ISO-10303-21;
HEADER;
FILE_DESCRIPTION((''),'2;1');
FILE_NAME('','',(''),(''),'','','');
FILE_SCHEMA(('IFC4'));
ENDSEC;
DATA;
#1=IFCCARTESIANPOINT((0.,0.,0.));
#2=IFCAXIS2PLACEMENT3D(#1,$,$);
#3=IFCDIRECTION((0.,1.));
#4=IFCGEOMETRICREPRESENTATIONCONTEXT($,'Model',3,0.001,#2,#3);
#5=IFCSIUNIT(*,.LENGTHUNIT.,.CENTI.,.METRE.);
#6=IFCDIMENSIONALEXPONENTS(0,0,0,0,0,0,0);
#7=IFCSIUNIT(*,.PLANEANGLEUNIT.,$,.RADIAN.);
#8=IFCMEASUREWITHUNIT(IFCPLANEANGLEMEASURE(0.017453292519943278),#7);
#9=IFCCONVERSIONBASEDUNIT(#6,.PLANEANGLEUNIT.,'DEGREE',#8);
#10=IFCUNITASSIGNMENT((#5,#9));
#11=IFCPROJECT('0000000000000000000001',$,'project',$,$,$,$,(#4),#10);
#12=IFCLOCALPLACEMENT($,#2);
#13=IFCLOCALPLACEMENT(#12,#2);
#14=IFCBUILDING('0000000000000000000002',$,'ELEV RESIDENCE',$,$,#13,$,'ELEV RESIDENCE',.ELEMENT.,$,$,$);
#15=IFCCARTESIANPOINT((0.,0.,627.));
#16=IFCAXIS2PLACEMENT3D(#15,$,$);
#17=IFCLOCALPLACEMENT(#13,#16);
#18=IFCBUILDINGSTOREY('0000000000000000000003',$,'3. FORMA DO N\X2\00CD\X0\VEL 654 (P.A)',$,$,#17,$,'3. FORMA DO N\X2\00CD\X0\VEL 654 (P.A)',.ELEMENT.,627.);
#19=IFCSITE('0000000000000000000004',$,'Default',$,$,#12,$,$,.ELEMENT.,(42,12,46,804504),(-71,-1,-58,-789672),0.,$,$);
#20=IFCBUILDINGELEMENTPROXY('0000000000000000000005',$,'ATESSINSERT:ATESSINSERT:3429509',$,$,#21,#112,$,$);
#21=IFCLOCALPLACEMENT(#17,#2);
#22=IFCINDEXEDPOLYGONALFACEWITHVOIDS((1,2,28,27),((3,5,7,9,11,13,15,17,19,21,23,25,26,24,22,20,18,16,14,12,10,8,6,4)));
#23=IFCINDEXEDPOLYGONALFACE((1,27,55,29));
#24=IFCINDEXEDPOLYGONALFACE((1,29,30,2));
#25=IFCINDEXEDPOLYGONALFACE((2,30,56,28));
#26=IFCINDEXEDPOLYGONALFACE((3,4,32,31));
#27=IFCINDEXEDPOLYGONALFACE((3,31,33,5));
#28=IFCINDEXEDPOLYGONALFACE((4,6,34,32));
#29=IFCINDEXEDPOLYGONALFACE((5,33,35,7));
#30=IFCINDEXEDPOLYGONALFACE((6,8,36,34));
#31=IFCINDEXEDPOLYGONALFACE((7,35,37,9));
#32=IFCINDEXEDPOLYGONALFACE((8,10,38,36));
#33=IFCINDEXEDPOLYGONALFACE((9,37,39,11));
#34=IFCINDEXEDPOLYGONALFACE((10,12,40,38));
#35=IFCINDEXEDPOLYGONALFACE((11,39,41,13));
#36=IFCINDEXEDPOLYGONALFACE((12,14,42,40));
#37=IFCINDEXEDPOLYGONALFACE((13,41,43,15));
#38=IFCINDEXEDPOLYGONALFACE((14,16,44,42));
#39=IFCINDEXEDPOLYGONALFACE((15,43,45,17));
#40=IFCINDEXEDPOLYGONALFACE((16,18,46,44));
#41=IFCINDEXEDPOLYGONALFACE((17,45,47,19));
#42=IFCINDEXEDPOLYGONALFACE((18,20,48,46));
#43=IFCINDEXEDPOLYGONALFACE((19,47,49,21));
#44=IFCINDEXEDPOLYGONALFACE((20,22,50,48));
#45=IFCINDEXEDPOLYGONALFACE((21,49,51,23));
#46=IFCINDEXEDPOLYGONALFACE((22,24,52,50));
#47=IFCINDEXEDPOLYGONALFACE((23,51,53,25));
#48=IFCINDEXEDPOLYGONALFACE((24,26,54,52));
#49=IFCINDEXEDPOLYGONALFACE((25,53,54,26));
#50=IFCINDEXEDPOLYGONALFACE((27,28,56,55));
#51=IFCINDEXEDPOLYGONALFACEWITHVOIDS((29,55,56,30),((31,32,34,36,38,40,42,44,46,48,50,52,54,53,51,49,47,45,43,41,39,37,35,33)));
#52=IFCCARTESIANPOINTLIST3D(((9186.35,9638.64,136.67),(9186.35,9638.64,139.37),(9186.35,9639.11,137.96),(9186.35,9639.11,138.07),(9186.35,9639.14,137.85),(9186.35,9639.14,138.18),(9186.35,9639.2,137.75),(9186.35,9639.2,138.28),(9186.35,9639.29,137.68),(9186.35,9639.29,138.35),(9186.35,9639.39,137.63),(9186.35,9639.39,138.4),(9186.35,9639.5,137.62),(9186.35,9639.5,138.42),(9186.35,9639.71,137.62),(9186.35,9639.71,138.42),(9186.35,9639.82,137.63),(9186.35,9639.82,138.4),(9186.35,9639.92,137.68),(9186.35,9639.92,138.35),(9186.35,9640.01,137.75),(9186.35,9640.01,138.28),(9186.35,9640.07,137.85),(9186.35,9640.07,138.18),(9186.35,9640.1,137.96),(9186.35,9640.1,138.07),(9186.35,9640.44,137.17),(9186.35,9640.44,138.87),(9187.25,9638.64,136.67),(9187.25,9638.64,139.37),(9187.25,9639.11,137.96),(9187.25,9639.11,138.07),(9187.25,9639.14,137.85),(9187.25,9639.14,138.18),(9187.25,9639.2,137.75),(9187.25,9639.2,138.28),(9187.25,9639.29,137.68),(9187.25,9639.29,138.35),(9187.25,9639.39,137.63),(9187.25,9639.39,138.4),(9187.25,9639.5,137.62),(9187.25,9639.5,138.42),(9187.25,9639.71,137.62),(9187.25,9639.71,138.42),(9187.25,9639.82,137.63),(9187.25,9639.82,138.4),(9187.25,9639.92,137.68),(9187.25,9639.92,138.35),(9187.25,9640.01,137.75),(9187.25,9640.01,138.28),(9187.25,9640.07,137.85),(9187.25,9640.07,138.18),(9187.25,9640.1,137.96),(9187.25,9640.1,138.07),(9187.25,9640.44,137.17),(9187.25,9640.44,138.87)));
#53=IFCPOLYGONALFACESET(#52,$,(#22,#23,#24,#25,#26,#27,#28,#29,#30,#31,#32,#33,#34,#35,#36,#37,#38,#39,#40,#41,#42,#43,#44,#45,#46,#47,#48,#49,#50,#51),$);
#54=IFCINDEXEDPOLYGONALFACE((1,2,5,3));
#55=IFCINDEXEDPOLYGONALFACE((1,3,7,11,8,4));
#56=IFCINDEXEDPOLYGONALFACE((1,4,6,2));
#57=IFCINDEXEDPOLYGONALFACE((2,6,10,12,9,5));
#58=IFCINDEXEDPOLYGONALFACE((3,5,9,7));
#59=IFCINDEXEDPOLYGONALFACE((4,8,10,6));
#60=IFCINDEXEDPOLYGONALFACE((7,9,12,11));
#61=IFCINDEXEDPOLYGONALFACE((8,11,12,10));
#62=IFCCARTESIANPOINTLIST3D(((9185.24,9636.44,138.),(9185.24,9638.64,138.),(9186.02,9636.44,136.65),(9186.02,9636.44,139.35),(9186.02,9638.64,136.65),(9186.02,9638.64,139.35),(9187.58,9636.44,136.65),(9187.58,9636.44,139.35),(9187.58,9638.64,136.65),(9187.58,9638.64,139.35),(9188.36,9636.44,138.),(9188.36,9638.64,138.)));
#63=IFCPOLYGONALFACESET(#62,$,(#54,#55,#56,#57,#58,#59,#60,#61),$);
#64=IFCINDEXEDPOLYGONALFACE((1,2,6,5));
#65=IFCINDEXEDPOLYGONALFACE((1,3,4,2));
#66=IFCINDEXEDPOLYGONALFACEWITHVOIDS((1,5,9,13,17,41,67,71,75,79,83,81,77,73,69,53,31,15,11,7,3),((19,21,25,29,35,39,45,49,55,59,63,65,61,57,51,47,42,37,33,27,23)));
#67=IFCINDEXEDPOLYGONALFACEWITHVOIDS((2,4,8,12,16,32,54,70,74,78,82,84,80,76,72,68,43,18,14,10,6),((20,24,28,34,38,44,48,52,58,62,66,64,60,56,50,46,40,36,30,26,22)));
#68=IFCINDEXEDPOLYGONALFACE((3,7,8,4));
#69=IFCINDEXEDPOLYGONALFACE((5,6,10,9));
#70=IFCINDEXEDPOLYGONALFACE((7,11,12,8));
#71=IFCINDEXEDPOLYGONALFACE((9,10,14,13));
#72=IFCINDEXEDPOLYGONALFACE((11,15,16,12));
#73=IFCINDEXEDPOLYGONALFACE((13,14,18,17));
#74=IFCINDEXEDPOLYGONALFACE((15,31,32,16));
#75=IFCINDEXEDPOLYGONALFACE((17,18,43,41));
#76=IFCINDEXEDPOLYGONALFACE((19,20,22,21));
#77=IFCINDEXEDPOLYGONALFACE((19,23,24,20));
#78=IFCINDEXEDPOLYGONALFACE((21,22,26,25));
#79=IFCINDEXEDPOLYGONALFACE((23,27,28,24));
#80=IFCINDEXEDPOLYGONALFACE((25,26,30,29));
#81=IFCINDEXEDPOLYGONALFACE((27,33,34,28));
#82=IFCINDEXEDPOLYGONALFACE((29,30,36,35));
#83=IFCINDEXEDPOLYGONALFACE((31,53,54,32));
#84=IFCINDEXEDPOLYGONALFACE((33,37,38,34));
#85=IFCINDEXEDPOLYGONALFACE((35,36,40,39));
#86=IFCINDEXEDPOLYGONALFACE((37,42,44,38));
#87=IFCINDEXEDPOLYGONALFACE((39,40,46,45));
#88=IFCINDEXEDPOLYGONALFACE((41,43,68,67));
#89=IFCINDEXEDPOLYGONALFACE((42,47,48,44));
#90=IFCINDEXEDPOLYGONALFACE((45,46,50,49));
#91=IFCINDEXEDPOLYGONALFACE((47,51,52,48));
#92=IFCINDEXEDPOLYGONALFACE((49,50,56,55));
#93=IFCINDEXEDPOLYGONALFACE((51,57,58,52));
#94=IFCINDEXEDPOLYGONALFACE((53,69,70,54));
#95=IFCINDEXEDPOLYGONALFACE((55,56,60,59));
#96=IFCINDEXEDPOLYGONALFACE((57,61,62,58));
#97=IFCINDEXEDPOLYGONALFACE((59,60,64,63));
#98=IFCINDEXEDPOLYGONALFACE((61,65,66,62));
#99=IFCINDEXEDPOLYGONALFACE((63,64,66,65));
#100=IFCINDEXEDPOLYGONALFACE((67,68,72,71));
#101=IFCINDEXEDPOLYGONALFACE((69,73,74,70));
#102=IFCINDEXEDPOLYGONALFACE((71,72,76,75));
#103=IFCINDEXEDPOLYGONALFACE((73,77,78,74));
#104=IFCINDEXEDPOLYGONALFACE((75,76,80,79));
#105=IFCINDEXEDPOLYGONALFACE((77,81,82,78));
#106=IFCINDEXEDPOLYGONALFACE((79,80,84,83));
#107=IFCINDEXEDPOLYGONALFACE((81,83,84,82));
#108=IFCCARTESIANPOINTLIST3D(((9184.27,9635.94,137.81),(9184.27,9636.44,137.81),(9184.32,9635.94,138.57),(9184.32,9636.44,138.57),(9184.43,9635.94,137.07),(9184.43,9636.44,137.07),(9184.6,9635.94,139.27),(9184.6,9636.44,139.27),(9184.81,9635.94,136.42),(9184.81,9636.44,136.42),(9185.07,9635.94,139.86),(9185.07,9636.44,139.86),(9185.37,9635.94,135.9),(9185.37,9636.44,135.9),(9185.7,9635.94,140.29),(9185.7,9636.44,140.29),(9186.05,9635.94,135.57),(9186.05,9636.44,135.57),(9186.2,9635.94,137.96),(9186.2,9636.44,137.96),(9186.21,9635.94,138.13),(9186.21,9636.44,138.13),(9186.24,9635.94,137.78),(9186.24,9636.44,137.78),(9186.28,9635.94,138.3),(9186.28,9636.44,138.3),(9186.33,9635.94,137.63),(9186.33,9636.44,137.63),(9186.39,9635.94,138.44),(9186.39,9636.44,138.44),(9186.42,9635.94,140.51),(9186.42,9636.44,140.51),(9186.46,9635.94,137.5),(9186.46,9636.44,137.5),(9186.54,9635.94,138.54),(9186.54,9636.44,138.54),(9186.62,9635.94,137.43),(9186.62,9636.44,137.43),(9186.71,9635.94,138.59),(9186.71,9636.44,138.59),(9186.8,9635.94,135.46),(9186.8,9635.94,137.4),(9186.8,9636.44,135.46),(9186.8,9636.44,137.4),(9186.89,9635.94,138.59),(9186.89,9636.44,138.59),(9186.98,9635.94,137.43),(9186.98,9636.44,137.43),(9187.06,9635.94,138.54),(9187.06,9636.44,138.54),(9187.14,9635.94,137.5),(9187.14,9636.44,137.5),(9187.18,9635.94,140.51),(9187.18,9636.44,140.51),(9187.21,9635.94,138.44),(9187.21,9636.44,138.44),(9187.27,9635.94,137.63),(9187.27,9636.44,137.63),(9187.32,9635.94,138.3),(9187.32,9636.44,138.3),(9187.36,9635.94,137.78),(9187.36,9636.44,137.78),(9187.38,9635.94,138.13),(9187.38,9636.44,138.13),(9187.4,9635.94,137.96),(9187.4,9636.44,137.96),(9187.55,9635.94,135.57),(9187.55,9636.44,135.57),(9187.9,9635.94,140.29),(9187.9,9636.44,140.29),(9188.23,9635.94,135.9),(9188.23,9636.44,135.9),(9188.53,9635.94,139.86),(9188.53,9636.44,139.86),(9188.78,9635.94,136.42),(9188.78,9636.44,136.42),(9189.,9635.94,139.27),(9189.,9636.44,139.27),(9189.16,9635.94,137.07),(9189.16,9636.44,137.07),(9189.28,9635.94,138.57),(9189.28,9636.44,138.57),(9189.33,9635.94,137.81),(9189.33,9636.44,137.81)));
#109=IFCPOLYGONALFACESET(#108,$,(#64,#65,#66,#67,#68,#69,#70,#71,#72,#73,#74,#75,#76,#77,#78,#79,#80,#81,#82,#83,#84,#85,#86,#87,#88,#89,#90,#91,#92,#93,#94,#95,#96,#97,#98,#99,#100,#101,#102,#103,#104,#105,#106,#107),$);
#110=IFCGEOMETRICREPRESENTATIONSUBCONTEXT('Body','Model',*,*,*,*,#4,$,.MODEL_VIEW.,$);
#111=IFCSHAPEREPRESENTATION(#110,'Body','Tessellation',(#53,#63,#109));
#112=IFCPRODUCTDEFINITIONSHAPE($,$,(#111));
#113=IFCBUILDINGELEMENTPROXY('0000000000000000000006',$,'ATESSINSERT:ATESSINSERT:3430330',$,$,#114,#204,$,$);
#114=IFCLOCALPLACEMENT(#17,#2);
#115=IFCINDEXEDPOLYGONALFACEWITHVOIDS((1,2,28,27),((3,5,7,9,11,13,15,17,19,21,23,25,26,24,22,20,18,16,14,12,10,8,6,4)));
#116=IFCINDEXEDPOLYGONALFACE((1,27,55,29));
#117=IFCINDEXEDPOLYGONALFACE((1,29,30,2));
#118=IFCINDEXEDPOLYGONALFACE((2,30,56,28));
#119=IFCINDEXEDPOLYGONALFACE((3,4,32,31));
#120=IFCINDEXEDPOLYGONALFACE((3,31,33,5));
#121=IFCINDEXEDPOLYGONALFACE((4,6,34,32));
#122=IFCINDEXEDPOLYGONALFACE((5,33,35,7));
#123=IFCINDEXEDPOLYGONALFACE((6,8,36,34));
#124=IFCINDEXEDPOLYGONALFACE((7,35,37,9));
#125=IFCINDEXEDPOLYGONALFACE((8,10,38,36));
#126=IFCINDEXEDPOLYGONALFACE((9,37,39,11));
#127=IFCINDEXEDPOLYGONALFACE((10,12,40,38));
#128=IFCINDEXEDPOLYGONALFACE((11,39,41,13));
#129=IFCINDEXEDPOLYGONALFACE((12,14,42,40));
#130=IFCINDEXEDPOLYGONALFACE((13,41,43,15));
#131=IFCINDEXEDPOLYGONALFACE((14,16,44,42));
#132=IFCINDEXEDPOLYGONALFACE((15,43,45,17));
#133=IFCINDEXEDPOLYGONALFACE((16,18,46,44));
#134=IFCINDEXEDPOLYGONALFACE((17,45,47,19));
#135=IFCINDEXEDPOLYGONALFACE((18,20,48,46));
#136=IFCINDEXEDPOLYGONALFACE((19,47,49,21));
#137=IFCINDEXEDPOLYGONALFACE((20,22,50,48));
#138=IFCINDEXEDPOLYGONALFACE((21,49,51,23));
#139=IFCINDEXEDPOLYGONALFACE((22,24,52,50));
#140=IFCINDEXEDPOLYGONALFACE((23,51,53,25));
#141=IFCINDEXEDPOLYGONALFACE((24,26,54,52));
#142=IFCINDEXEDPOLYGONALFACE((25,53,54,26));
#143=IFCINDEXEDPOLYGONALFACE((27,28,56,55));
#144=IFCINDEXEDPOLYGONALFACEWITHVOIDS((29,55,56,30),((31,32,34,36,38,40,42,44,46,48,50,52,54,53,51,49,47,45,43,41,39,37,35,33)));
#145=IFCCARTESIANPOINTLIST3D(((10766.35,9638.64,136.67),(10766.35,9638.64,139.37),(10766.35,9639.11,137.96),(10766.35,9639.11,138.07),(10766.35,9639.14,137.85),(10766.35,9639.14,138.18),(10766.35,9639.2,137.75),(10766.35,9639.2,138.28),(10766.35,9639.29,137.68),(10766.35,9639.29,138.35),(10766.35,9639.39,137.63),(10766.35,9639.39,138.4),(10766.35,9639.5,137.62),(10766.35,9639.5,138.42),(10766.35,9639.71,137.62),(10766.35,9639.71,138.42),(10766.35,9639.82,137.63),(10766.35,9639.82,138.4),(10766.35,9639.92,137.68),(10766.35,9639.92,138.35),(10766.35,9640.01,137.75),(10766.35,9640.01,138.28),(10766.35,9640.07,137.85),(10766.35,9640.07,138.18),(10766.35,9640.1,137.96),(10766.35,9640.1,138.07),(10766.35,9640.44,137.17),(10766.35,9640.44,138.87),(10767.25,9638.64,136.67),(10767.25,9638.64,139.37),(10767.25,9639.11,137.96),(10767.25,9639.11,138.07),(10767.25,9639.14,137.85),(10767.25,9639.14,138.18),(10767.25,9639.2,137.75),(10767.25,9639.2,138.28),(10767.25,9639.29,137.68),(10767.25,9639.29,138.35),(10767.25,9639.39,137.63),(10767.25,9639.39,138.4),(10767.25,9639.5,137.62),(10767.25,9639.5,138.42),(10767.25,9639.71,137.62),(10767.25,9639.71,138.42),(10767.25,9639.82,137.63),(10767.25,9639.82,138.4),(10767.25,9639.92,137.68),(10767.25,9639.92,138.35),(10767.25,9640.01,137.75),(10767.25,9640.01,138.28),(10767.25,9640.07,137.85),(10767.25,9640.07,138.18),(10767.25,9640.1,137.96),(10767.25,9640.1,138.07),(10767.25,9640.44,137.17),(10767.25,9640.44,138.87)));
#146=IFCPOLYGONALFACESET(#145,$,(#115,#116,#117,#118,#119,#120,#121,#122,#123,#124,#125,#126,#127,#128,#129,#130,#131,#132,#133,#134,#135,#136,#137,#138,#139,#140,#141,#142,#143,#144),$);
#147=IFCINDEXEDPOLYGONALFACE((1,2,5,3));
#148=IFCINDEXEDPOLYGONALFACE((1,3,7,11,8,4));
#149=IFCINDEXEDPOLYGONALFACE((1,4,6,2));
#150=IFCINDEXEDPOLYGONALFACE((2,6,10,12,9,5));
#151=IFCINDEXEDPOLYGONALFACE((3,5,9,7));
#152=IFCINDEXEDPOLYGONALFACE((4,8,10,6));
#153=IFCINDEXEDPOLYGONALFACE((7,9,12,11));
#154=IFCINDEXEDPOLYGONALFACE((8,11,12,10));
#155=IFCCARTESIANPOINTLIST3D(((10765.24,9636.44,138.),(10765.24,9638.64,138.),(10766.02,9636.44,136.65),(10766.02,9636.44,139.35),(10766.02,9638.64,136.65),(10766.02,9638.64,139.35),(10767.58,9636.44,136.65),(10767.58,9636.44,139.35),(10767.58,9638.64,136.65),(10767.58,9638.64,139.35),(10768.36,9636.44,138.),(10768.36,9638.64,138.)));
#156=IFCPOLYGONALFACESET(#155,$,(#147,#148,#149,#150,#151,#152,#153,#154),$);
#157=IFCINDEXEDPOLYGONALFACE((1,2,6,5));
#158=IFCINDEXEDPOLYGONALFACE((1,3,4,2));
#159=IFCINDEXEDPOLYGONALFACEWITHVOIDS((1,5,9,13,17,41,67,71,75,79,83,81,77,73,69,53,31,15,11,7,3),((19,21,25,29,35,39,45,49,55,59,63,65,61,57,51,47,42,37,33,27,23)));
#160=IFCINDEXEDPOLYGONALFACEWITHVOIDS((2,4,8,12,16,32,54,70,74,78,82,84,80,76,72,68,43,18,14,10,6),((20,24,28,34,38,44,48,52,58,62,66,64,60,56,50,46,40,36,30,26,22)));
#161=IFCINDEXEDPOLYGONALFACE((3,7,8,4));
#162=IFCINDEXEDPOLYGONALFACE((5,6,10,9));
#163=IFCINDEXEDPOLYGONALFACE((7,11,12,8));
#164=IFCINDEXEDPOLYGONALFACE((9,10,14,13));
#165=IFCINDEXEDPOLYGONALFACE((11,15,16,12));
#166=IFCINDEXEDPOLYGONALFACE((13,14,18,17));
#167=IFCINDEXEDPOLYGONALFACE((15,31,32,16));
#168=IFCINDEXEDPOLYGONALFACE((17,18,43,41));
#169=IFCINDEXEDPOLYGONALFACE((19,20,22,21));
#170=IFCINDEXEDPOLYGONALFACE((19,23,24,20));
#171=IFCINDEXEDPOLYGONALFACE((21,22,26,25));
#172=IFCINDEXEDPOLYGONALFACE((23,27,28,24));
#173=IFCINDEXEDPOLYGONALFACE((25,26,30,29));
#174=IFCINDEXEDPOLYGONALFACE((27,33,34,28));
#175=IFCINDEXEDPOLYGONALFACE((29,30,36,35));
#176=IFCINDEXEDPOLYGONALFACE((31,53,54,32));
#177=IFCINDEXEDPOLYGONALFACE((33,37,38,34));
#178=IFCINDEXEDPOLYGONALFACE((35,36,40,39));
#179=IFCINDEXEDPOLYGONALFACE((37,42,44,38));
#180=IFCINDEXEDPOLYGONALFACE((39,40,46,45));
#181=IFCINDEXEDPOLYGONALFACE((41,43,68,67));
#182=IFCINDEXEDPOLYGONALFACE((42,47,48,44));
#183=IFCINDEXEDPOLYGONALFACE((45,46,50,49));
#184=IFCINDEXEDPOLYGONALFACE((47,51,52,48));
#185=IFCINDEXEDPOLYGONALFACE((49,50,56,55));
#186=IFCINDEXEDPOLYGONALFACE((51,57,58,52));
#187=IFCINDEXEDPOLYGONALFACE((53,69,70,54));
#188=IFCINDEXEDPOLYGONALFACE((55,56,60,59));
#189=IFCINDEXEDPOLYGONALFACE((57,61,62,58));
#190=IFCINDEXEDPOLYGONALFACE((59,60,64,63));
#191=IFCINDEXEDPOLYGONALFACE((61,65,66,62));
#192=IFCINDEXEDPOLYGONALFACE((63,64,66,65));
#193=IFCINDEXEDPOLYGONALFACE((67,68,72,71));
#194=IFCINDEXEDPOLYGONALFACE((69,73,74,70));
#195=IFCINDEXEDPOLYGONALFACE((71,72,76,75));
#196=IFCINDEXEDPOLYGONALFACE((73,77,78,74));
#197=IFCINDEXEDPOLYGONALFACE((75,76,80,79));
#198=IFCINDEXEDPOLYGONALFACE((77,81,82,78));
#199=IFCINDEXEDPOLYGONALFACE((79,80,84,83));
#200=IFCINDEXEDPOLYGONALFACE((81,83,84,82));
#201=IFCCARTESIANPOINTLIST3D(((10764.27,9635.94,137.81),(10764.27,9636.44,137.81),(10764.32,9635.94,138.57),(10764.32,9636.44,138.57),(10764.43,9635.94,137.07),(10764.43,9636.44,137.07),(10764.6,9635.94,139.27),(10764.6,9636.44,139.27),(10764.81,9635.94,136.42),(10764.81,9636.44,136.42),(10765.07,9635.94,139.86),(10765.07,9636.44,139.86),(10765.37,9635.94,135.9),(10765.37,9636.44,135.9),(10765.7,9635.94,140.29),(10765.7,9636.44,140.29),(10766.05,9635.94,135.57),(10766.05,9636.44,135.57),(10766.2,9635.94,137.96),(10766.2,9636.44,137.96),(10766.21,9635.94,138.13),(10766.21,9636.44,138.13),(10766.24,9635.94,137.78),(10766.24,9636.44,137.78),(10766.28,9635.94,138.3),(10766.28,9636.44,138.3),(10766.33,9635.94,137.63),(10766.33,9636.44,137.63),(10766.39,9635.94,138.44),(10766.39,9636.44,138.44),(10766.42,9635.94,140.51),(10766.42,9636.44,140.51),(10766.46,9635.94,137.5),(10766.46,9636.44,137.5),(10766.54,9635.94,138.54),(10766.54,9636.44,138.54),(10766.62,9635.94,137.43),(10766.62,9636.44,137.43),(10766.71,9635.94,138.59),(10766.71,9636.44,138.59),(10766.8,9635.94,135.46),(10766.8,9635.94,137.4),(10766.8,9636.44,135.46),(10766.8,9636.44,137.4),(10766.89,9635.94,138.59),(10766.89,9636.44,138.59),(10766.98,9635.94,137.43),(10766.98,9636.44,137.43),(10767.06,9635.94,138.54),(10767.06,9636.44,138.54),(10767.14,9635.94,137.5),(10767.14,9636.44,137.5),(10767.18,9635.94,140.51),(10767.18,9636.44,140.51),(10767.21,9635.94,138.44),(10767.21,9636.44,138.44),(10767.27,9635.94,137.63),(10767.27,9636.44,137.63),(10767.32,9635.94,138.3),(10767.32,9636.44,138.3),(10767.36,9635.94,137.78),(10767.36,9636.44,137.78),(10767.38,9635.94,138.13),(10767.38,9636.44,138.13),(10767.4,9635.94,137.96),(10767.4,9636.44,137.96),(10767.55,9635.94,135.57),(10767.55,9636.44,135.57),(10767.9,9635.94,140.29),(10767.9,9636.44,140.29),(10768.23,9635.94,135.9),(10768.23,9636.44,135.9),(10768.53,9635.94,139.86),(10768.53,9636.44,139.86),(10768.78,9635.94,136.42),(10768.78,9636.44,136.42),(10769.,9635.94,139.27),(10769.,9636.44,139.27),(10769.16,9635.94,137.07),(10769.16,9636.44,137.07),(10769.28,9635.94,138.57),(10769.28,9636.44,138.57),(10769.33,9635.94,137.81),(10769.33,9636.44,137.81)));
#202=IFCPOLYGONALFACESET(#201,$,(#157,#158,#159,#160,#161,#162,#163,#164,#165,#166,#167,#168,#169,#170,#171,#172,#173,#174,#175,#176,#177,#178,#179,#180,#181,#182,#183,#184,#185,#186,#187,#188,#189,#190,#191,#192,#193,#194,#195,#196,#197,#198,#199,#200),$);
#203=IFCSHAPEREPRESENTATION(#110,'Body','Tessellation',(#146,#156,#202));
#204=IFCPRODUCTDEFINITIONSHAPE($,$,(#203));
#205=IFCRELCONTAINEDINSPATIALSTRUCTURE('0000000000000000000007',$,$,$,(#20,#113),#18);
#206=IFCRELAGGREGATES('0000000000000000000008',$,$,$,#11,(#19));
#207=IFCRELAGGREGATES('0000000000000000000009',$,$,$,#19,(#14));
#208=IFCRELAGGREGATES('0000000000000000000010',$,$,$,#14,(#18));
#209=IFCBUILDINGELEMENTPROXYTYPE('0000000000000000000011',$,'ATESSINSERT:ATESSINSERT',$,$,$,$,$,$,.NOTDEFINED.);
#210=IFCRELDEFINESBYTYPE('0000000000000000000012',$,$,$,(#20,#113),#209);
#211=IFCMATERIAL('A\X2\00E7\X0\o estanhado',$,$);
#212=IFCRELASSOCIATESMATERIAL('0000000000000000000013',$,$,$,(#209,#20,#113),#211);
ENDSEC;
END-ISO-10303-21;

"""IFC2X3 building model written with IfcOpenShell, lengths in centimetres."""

from ifc_helpers import new_model, entity, si_unit, converted_unit, direction, frame, frame_2d, origin, place, context, subcontext, project, spatial, polyline, circle_curve, parameter, trimmed, segment, composite_curve, hollow_circle, outline, extrude, source, transform, mapped, material, type_object, type_shapes, element, save


model = new_model("IFC2X3")

# Units and contexts
model_context = context("Model", 3, precision=0.001, world=origin(), true_north=direction((0.0, 1.0)))
body_context = subcontext(model_context, "Body", "Model", "MODEL_VIEW")
ifc_project = project(units=[si_unit("LENGTHUNIT", "METRE", prefix="CENTI"), converted_unit("PLANEANGLEUNIT", "DEGREE", entity("IfcPlaneAngleMeasure", 0.017453292519943278), si_unit("PLANEANGLEUNIT", "RADIAN"), dimensions=[0, 0, 0, 0, 0, 0, 0])], contexts=[model_context])

# Site, building, storey
site_placement = place(None, origin())
site = spatial("IfcSite", under=ifc_project, at=site_placement, Name="Default", CompositionType="ELEMENT", RefLatitude=(42, 12, 46, 804504), RefLongitude=(-71, -1, -58, -789672), RefElevation=0.0)
building_placement = place(site_placement, origin())
building = spatial("IfcBuilding", under=site, at=building_placement, Name="ELEV RESIDENCE", LongName="ELEV RESIDENCE", CompositionType="ELEMENT")
storey_placement = place(building_placement, frame((0.0, 0.0, 627.0)))
storey = spatial("IfcBuildingStorey", under=building, at=storey_placement, Name="3. FORMA DO NÍVEL 654 (P.A)", LongName="3. FORMA DO NÍVEL 654 (P.A)", CompositionType="ELEMENT", Elevation=627.0)

# Building element proxies
ifc_material_1 = material(Name="Aço estanhado")
building_element_proxy_type_1 = type_object("IfcBuildingElementProxyType", Name="ATESSINSERT:ATESSINSERT", PredefinedType="NOTDEFINED", material=ifc_material_1)
shared_shape_1 = source(origin(), body_context, "Body", "SweptSolid", [
    extrude(outline(polyline([(-1.35, -0.9), (1.35, -0.9), (0.85, 0.9), (-0.85, 0.9), (-1.35, -0.9)]), holes=[composite_curve([segment(trimmed(circle_curve(frame_2d((0.0, 0.17), x_axis=(1.0, 0.0)), 0.4), [parameter(0.0)], [parameter(180.0)], True, "PARAMETER"), False, "CONTINUOUS"), segment(polyline([(0.4, 0.17), (0.4, -0.03)]), True, "CONTINUOUS"), segment(trimmed(circle_curve(frame_2d((0.0, -0.03), x_axis=(1.0, 0.0)), 0.4), [parameter(180.0)], [parameter(0.0)], True, "PARAMETER"), False, "CONTINUOUS"), segment(polyline([(-0.4, -0.03), (-0.4, 0.17)]), True, "CONTINUOUS")], self_intersect=False)]), frame((-1.4, -0.45, 30.02), z_axis=(0.0, 1.0, 0.0), x_axis=(0.0, 0.0, 1.0)), (0.0, 0.0, 1.0), 0.9),
    extrude(outline(polyline([(-0.78, -1.35), (0.78, -1.35), (1.56, 0.0), (0.78, 1.35), (-0.78, 1.35), (-1.56, 0.0), (-0.78, -1.35)])), frame((-4.5, 0.0, 30.0), z_axis=(1.0, 0.0, 0.0), x_axis=(0.0, 0.5, 0.866025)), (0.0, 0.0, 1.0), 2.2),
    extrude(hollow_circle(Radius=2.54, WallThickness=1.94, at=frame_2d((0.0, 0.0), x_axis=(1.0, 0.0))), frame((-5.0, 0.0, 30.0), z_axis=(1.0, 0.0, 0.0), x_axis=(0.0, 0.0, -1.0)), (0.0, 0.0, 1.0), 0.5),
])
type_shapes(building_element_proxy_type_1, [shared_shape_1])
for number, where, z_axis, x_axis, name in (
    (1, (9186.8, 9640.94, 108.0), (0.0, 0.0, 1.0), (0.0, 1.0, 0.0), "ATESSINSERT:ATESSINSERT:3429509"),
    (2, (10766.8, 9640.94, 108.0), (0.0, 0.0, 1.0), (0.0, 1.0, 0.0), "ATESSINSERT:ATESSINSERT:3430330"),
):
    element("IfcBuildingElementProxy", number, at=place(storey_placement, frame(where, z_axis=z_axis, x_axis=x_axis)), inside=storey, type_object=building_element_proxy_type_1, material=ifc_material_1, Name=name, context=body_context, shape_type="MappedRepresentation", body=[
        mapped(shared_shape_1, transform((0.0, 0.0, 0.0), scale=1.0)),
    ])

save(model, "model.ifc")
